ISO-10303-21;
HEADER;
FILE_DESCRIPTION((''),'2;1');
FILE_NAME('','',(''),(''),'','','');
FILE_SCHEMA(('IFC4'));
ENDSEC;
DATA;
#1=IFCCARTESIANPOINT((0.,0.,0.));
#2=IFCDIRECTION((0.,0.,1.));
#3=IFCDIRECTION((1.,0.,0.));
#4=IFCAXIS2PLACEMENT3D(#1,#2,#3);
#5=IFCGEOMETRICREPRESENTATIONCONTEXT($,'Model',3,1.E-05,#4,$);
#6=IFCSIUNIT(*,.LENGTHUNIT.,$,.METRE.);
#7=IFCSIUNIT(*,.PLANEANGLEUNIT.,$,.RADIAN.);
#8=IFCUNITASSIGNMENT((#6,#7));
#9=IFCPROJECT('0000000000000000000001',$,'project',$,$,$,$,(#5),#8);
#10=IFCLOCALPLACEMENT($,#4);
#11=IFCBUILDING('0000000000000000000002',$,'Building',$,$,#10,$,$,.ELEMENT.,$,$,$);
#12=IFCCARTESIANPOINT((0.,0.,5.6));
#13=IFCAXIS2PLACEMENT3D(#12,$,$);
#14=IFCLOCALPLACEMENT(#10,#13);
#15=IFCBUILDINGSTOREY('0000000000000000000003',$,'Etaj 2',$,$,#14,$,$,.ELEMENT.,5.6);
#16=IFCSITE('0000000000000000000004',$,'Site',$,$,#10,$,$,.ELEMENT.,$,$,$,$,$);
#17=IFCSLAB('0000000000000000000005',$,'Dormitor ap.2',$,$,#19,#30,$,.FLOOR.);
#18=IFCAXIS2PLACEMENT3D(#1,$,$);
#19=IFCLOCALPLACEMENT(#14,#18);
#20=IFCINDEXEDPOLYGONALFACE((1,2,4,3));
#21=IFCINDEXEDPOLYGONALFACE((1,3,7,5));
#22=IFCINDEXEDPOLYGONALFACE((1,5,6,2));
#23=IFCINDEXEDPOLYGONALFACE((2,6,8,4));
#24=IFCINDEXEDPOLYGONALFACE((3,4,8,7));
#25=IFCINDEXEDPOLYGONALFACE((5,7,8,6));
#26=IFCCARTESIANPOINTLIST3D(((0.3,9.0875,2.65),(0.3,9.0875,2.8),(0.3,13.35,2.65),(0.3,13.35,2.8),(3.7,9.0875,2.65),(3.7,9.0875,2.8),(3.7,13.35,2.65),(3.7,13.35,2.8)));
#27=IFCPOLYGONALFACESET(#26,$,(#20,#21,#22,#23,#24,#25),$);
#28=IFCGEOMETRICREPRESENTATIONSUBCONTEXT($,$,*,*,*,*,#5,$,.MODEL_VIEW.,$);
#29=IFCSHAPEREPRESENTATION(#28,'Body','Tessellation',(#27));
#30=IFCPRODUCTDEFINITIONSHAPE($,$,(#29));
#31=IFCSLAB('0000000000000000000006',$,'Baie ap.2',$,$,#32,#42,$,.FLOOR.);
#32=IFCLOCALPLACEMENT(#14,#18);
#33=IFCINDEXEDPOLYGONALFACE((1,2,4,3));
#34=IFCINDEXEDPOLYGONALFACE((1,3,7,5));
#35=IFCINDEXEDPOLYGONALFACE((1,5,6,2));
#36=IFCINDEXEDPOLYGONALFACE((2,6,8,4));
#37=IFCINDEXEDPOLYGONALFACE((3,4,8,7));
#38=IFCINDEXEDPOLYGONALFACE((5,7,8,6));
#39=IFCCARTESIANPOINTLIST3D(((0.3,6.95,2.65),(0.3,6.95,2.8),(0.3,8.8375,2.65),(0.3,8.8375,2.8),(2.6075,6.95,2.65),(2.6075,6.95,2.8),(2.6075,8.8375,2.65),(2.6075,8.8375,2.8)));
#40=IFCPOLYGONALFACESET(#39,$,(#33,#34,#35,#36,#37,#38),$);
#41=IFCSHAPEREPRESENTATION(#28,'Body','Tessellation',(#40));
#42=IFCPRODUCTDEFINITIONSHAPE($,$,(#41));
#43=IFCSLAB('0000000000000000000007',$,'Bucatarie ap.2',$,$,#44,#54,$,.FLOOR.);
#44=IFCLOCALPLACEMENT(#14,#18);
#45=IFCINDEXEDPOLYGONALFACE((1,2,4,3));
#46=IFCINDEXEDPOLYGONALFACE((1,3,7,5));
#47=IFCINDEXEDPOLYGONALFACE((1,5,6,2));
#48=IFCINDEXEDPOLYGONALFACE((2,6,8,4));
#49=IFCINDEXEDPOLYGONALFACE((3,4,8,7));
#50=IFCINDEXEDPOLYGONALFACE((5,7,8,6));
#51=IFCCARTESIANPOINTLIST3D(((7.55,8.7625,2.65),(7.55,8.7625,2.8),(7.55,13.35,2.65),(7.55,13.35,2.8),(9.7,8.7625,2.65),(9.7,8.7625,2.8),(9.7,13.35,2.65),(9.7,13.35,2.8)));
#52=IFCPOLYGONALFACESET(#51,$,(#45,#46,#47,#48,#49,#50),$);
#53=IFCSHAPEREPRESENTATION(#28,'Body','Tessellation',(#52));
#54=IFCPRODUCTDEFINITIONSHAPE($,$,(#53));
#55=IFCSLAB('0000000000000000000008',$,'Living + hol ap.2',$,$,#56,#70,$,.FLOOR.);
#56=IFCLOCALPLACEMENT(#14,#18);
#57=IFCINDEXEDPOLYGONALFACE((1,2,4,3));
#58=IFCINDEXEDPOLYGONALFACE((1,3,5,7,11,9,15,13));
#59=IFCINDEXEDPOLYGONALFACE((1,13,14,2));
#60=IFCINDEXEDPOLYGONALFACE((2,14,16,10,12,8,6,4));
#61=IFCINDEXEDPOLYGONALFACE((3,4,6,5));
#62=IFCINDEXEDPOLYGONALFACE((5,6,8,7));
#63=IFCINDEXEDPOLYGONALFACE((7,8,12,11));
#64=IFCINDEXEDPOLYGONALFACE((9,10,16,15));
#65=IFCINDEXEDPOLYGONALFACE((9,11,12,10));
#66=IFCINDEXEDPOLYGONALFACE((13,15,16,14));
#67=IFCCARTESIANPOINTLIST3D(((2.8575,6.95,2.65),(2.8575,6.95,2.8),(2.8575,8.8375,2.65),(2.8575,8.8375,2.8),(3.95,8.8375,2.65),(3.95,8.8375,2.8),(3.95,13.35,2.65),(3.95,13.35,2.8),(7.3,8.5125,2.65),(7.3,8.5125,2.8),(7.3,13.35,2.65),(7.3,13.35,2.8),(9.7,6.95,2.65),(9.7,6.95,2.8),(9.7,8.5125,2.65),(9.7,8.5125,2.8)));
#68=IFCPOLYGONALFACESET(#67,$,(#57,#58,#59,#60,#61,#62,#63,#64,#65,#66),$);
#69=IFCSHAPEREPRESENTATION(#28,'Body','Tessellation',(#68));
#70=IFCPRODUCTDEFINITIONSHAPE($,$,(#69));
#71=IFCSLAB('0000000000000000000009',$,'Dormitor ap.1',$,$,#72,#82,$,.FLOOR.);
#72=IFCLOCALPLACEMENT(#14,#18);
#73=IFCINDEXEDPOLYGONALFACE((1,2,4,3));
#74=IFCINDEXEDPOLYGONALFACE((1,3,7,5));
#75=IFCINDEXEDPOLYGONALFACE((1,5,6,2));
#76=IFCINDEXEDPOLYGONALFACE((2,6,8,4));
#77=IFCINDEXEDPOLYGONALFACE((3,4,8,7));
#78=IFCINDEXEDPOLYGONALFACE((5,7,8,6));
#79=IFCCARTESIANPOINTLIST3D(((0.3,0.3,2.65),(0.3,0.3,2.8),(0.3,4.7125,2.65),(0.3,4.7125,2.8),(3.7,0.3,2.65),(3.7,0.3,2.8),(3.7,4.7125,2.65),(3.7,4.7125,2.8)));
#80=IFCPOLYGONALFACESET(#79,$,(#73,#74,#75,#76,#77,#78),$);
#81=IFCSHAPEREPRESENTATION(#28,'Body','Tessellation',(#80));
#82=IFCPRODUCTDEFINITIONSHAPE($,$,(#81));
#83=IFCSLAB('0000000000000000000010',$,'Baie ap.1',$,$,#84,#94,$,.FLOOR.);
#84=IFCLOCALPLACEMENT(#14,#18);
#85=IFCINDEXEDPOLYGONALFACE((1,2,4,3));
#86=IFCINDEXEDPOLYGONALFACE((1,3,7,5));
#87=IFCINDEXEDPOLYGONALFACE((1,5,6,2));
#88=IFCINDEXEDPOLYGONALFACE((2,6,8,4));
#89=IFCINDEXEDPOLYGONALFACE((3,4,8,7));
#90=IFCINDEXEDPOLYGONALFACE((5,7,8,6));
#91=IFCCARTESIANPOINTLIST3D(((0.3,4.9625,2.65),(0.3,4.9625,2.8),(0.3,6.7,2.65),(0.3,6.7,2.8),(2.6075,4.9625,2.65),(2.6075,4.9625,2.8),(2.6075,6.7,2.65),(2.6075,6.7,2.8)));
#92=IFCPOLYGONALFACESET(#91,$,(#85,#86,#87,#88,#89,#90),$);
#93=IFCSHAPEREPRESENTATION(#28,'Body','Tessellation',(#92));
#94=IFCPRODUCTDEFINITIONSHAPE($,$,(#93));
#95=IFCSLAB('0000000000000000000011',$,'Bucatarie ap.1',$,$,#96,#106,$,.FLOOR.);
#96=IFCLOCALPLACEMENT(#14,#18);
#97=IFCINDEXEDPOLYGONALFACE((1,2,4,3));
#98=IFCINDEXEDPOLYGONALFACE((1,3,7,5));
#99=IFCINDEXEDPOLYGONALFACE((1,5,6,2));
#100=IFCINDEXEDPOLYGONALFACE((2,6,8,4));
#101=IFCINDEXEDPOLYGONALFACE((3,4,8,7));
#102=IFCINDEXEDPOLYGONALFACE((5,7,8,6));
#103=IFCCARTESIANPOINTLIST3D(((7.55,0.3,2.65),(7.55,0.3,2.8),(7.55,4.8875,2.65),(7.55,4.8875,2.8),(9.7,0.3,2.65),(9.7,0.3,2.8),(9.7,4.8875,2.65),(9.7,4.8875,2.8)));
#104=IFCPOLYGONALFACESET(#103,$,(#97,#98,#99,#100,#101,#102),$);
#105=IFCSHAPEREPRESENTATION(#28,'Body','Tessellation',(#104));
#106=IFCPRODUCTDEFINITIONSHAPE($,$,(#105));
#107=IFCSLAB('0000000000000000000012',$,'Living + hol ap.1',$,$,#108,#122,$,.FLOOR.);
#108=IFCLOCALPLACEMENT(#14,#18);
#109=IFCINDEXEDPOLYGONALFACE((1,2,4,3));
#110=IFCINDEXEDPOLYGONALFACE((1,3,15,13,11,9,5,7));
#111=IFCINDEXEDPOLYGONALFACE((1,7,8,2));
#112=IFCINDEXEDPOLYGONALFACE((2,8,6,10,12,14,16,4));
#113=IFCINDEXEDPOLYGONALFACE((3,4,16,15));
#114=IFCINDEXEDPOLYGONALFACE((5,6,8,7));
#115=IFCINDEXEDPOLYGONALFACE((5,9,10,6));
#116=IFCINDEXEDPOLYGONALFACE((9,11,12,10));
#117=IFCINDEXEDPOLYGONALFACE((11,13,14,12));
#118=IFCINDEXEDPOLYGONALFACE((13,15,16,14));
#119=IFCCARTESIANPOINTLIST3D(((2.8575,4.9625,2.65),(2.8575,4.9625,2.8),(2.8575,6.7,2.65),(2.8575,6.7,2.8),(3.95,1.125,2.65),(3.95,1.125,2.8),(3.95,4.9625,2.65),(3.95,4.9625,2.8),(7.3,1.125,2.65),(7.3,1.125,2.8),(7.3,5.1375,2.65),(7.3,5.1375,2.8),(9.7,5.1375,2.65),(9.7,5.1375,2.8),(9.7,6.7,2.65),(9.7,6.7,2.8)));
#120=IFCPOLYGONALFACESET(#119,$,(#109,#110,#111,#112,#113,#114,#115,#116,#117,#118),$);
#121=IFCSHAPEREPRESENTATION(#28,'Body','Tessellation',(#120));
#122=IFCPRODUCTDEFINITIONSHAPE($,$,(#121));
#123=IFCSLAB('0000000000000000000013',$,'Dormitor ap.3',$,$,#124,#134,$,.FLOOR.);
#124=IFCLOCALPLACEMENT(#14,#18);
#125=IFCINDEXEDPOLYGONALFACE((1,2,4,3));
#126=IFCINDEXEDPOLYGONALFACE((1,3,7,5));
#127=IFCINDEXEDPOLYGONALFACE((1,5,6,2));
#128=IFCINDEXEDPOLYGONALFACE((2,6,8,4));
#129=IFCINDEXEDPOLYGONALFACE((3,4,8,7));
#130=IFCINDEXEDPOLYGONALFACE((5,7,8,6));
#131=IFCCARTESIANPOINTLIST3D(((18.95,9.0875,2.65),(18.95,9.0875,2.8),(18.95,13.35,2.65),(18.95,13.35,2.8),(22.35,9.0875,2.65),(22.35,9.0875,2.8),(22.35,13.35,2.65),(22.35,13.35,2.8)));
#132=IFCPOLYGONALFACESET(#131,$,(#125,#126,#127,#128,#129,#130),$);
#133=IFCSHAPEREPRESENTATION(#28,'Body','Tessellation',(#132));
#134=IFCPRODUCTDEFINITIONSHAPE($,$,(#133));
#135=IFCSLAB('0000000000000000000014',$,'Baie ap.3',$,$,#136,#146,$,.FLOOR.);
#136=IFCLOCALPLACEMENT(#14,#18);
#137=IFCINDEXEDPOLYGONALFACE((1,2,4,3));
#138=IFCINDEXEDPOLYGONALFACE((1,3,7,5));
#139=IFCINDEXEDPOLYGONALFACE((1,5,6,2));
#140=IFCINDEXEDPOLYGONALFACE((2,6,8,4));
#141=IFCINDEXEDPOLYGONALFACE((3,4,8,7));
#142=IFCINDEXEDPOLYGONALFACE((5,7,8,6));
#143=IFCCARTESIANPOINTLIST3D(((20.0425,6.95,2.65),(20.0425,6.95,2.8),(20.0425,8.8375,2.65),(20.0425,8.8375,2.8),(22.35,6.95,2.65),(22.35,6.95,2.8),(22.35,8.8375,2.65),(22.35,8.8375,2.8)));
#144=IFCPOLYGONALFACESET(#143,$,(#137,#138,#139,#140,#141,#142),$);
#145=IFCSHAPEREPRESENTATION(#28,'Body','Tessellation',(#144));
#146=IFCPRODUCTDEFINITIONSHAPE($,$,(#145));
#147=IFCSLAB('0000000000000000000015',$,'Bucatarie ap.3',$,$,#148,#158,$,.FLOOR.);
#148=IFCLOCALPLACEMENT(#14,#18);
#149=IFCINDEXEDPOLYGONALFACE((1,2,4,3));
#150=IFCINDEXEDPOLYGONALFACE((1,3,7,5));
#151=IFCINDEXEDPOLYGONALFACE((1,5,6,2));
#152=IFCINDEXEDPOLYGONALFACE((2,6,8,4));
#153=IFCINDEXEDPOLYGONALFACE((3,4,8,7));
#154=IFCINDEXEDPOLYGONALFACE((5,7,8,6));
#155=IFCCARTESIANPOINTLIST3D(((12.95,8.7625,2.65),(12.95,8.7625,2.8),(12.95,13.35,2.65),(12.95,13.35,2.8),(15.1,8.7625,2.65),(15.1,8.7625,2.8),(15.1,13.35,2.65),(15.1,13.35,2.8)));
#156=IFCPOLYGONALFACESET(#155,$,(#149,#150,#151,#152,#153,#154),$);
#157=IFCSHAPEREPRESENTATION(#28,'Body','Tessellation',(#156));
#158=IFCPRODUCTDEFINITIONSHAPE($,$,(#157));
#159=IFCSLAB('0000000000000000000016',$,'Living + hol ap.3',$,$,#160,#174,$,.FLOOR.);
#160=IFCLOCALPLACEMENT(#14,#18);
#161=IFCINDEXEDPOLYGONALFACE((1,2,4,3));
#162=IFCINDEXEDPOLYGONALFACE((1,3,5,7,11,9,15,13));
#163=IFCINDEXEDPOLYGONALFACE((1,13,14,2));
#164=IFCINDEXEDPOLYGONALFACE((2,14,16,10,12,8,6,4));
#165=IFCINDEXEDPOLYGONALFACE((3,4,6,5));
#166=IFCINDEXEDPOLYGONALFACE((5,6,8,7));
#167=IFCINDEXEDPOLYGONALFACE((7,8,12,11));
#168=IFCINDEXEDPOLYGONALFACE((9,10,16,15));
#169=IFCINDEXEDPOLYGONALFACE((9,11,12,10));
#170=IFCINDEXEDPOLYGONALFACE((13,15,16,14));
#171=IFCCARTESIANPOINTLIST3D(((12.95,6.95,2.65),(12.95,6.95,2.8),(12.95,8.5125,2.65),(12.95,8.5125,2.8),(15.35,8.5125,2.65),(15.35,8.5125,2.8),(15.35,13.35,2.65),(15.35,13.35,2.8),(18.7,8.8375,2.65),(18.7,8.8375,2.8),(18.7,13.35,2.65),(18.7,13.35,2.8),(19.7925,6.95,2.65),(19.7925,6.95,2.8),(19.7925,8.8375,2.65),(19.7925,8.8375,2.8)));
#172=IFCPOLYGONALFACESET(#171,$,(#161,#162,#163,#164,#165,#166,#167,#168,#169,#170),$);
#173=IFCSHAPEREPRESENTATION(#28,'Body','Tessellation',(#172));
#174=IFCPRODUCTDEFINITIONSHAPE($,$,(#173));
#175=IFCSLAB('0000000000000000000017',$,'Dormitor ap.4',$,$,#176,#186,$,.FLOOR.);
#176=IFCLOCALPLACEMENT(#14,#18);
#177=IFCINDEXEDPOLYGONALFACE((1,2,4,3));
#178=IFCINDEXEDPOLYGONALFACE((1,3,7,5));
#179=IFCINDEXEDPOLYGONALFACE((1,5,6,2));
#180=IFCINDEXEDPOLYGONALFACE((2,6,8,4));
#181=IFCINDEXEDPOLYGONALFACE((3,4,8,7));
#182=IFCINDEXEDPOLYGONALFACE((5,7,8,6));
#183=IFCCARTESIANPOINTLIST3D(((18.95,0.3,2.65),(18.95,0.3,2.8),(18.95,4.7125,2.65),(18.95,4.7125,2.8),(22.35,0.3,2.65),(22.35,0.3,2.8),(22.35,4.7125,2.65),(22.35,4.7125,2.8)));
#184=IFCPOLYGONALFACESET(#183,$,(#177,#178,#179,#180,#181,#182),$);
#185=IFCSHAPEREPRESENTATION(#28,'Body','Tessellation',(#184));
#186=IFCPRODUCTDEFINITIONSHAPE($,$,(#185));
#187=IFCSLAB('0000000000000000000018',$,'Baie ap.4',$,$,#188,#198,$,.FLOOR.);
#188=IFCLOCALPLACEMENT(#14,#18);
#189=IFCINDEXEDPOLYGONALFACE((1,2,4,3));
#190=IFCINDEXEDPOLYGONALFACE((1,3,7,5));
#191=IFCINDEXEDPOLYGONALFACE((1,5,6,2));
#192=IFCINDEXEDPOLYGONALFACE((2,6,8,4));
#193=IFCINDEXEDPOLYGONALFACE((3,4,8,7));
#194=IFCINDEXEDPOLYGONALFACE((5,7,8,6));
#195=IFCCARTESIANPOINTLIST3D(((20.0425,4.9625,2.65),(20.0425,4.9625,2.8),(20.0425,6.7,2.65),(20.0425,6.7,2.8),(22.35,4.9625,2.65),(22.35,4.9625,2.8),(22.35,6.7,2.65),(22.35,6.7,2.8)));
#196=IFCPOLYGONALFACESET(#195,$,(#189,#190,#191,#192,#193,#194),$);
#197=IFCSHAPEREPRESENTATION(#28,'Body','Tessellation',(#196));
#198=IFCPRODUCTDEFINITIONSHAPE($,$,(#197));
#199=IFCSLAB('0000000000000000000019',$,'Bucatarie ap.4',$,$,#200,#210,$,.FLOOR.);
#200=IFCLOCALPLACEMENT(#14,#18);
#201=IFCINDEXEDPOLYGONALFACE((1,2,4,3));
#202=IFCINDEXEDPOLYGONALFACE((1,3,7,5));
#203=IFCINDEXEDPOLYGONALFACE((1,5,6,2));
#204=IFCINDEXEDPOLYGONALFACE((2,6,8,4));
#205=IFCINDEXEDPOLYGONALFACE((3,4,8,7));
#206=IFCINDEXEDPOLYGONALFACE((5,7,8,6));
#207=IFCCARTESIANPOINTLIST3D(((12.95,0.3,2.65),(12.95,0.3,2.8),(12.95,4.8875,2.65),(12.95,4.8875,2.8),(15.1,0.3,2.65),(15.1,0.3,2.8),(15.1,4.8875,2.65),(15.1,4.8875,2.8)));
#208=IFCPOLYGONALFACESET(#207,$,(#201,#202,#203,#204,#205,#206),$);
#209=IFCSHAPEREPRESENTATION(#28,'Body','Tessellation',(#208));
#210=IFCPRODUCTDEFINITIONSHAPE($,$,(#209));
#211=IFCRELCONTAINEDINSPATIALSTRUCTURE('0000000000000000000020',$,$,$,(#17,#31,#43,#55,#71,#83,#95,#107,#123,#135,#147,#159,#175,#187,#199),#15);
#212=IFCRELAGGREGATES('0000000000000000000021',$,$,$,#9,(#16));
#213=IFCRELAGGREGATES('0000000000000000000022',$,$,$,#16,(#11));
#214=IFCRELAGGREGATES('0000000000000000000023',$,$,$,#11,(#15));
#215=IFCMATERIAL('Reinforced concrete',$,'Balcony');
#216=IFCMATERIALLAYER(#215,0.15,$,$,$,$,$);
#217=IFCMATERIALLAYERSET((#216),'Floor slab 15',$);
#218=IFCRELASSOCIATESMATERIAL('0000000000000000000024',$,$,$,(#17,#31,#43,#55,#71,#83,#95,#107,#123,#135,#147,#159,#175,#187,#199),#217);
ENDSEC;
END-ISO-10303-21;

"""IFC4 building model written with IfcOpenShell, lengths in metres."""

from ifc_helpers import new_model, si_unit, frame, origin, origin_with_axes, place, context, subcontext, project, spatial, polyline, outline, extrude, material, layer, layer_set, layer_usage, element, save


model = new_model("IFC4")

# Units and contexts
model_context = context("Model", 3, precision=1e-05, world=origin_with_axes())
sub_context = subcontext(model_context, None, None, "MODEL_VIEW")
ifc_project = project(units=[si_unit("LENGTHUNIT", "METRE"), si_unit("PLANEANGLEUNIT", "RADIAN")], contexts=[model_context])

# Site, building, storey
placement = place(None, origin_with_axes())
site = spatial("IfcSite", under=ifc_project, at=placement, Name="Site", CompositionType="ELEMENT")
building = spatial("IfcBuilding", under=site, at=placement, Name="Building", CompositionType="ELEMENT")
storey_placement = place(placement, frame((0.0, 0.0, 5.6)))
storey = spatial("IfcBuildingStorey", under=building, at=storey_placement, Name="Etaj 2", CompositionType="ELEMENT", Elevation=5.6)

# Slabs
ifc_material_1 = material(Name="Reinforced concrete", Category="Balcony")
ifc_layer = layer(ifc_material_1, 0.15)
ifc_layer_set = layer_set([ifc_layer], Name="Floor slab 15")
ifc_layer_usage = layer_usage(ifc_layer_set, "AXIS3", "POSITIVE", 0.0)
slab_1_placement = place(storey_placement, frame((0.0, 0.0, 2.65)))
element("IfcSlab", 1, at=slab_1_placement, inside=storey, material=ifc_layer_usage, Name="Dormitor ap.2", PredefinedType="FLOOR", context=sub_context, shape_type="SweptSolid", body=[
    extrude(outline(polyline([(3.7, 13.35), (0.3, 13.35), (0.3, 9.0875), (3.7, 9.0875), (3.7, 13.35)])), origin(), (0.0, 0.0, 1.0), 0.15),
])
slab_2_placement = place(storey_placement, frame((0.0, 0.0, 2.65)))
element("IfcSlab", 2, at=slab_2_placement, inside=storey, material=ifc_layer_usage, Name="Baie ap.2", PredefinedType="FLOOR", context=sub_context, shape_type="SweptSolid", body=[
    extrude(outline(polyline([(2.6075, 8.8375), (0.3, 8.8375), (0.3, 6.95), (2.6075, 6.95), (2.6075, 8.8375)])), origin(), (0.0, 0.0, 1.0), 0.15),
])
slab_3_placement = place(storey_placement, frame((0.0, 0.0, 2.65)))
element("IfcSlab", 3, at=slab_3_placement, inside=storey, material=ifc_layer_usage, Name="Bucatarie ap.2", PredefinedType="FLOOR", context=sub_context, shape_type="SweptSolid", body=[
    extrude(outline(polyline([(7.55, 13.35), (7.55, 8.7625), (9.7, 8.7625), (9.7, 13.35), (7.55, 13.35)])), origin(), (0.0, 0.0, 1.0), 0.15),
])
slab_4_placement = place(storey_placement, frame((0.0, 0.0, 2.65)))
element("IfcSlab", 4, at=slab_4_placement, inside=storey, material=ifc_layer_usage, Name="Living + hol ap.2", PredefinedType="FLOOR", context=sub_context, shape_type="SweptSolid", body=[
    extrude(outline(polyline([(7.3, 13.35), (3.95, 13.35), (3.95, 8.8375), (2.8575, 8.8375), (2.8575, 6.95), (9.7, 6.95), (9.7, 8.5125), (7.3, 8.5125), (7.3, 13.35)])), origin(), (0.0, 0.0, 1.0), 0.15),
])
slab_5_placement = place(storey_placement, frame((0.0, 0.0, 2.65)))
element("IfcSlab", 5, at=slab_5_placement, inside=storey, material=ifc_layer_usage, Name="Dormitor ap.1", PredefinedType="FLOOR", context=sub_context, shape_type="SweptSolid", body=[
    extrude(outline(polyline([(0.3, 4.7125), (0.3, 0.3), (3.7, 0.3), (3.7, 4.7125), (0.3, 4.7125)])), origin(), (0.0, 0.0, 1.0), 0.15),
])
slab_6_placement = place(storey_placement, frame((0.0, 0.0, 2.65)))
element("IfcSlab", 6, at=slab_6_placement, inside=storey, material=ifc_layer_usage, Name="Baie ap.1", PredefinedType="FLOOR", context=sub_context, shape_type="SweptSolid", body=[
    extrude(outline(polyline([(2.6075, 6.7), (0.3, 6.7), (0.3, 4.9625), (2.6075, 4.9625), (2.6075, 6.7)])), origin(), (0.0, 0.0, 1.0), 0.15),
])
slab_7_placement = place(storey_placement, frame((0.0, 0.0, 2.65)))
element("IfcSlab", 7, at=slab_7_placement, inside=storey, material=ifc_layer_usage, Name="Bucatarie ap.1", PredefinedType="FLOOR", context=sub_context, shape_type="SweptSolid", body=[
    extrude(outline(polyline([(7.55, 4.8875), (7.55, 0.3), (9.7, 0.3), (9.7, 4.8875), (7.55, 4.8875)])), origin(), (0.0, 0.0, 1.0), 0.15),
])
slab_8_placement = place(storey_placement, frame((0.0, 0.0, 2.65)))
element("IfcSlab", 8, at=slab_8_placement, inside=storey, material=ifc_layer_usage, Name="Living + hol ap.1", PredefinedType="FLOOR", context=sub_context, shape_type="SweptSolid", body=[
    extrude(outline(polyline([(7.3, 5.1375), (9.7, 5.1375), (9.7, 6.7), (2.8575, 6.7), (2.8575, 4.9625), (3.95, 4.9625), (3.95, 1.125), (7.3, 1.125), (7.3, 5.1375)])), origin(), (0.0, 0.0, 1.0), 0.15),
])
slab_9_placement = place(storey_placement, frame((0.0, 0.0, 2.65)))
element("IfcSlab", 9, at=slab_9_placement, inside=storey, material=ifc_layer_usage, Name="Dormitor ap.3", PredefinedType="FLOOR", context=sub_context, shape_type="SweptSolid", body=[
    extrude(outline(polyline([(22.35, 13.35), (18.95, 13.35), (18.95, 9.0875), (22.35, 9.0875), (22.35, 13.35)])), origin(), (0.0, 0.0, 1.0), 0.15),
])
slab_10_placement = place(storey_placement, frame((0.0, 0.0, 2.65)))
element("IfcSlab", 10, at=slab_10_placement, inside=storey, material=ifc_layer_usage, Name="Baie ap.3", PredefinedType="FLOOR", context=sub_context, shape_type="SweptSolid", body=[
    extrude(outline(polyline([(22.35, 8.8375), (20.0425, 8.8375), (20.0425, 6.95), (22.35, 6.95), (22.35, 8.8375)])), origin(), (0.0, 0.0, 1.0), 0.15),
])
slab_11_placement = place(storey_placement, frame((0.0, 0.0, 2.65)))
element("IfcSlab", 11, at=slab_11_placement, inside=storey, material=ifc_layer_usage, Name="Bucatarie ap.3", PredefinedType="FLOOR", context=sub_context, shape_type="SweptSolid", body=[
    extrude(outline(polyline([(15.1, 13.35), (12.95, 13.35), (12.95, 8.7625), (15.1, 8.7625), (15.1, 13.35)])), origin(), (0.0, 0.0, 1.0), 0.15),
])
slab_12_placement = place(storey_placement, frame((0.0, 0.0, 2.65)))
element("IfcSlab", 12, at=slab_12_placement, inside=storey, material=ifc_layer_usage, Name="Living + hol ap.3", PredefinedType="FLOOR", context=sub_context, shape_type="SweptSolid", body=[
    extrude(outline(polyline([(15.35, 13.35), (15.35, 8.5125), (12.95, 8.5125), (12.95, 6.95), (19.7925, 6.95), (19.7925, 8.8375), (18.7, 8.8375), (18.7, 13.35), (15.35, 13.35)])), origin(), (0.0, 0.0, 1.0), 0.15),
])
slab_13_placement = place(storey_placement, frame((0.0, 0.0, 2.65)))
element("IfcSlab", 13, at=slab_13_placement, inside=storey, material=ifc_layer_usage, Name="Dormitor ap.4", PredefinedType="FLOOR", context=sub_context, shape_type="SweptSolid", body=[
    extrude(outline(polyline([(22.35, 4.7125), (18.95, 4.7125), (18.95, 0.3), (22.35, 0.3), (22.35, 4.7125)])), origin(), (0.0, 0.0, 1.0), 0.15),
])
slab_14_placement = place(storey_placement, frame((0.0, 0.0, 2.65)))
element("IfcSlab", 14, at=slab_14_placement, inside=storey, material=ifc_layer_usage, Name="Baie ap.4", PredefinedType="FLOOR", context=sub_context, shape_type="SweptSolid", body=[
    extrude(outline(polyline([(22.35, 6.7), (20.0425, 6.7), (20.0425, 4.9625), (22.35, 4.9625), (22.35, 6.7)])), origin(), (0.0, 0.0, 1.0), 0.15),
])
slab_15_placement = place(storey_placement, frame((0.0, 0.0, 2.65)))
element("IfcSlab", 15, at=slab_15_placement, inside=storey, material=ifc_layer_usage, Name="Bucatarie ap.4", PredefinedType="FLOOR", context=sub_context, shape_type="SweptSolid", body=[
    extrude(outline(polyline([(12.95, 4.8875), (12.95, 0.3), (15.1, 0.3), (15.1, 4.8875), (12.95, 4.8875)])), origin(), (0.0, 0.0, 1.0), 0.15),
])

save(model, "model.ifc")
